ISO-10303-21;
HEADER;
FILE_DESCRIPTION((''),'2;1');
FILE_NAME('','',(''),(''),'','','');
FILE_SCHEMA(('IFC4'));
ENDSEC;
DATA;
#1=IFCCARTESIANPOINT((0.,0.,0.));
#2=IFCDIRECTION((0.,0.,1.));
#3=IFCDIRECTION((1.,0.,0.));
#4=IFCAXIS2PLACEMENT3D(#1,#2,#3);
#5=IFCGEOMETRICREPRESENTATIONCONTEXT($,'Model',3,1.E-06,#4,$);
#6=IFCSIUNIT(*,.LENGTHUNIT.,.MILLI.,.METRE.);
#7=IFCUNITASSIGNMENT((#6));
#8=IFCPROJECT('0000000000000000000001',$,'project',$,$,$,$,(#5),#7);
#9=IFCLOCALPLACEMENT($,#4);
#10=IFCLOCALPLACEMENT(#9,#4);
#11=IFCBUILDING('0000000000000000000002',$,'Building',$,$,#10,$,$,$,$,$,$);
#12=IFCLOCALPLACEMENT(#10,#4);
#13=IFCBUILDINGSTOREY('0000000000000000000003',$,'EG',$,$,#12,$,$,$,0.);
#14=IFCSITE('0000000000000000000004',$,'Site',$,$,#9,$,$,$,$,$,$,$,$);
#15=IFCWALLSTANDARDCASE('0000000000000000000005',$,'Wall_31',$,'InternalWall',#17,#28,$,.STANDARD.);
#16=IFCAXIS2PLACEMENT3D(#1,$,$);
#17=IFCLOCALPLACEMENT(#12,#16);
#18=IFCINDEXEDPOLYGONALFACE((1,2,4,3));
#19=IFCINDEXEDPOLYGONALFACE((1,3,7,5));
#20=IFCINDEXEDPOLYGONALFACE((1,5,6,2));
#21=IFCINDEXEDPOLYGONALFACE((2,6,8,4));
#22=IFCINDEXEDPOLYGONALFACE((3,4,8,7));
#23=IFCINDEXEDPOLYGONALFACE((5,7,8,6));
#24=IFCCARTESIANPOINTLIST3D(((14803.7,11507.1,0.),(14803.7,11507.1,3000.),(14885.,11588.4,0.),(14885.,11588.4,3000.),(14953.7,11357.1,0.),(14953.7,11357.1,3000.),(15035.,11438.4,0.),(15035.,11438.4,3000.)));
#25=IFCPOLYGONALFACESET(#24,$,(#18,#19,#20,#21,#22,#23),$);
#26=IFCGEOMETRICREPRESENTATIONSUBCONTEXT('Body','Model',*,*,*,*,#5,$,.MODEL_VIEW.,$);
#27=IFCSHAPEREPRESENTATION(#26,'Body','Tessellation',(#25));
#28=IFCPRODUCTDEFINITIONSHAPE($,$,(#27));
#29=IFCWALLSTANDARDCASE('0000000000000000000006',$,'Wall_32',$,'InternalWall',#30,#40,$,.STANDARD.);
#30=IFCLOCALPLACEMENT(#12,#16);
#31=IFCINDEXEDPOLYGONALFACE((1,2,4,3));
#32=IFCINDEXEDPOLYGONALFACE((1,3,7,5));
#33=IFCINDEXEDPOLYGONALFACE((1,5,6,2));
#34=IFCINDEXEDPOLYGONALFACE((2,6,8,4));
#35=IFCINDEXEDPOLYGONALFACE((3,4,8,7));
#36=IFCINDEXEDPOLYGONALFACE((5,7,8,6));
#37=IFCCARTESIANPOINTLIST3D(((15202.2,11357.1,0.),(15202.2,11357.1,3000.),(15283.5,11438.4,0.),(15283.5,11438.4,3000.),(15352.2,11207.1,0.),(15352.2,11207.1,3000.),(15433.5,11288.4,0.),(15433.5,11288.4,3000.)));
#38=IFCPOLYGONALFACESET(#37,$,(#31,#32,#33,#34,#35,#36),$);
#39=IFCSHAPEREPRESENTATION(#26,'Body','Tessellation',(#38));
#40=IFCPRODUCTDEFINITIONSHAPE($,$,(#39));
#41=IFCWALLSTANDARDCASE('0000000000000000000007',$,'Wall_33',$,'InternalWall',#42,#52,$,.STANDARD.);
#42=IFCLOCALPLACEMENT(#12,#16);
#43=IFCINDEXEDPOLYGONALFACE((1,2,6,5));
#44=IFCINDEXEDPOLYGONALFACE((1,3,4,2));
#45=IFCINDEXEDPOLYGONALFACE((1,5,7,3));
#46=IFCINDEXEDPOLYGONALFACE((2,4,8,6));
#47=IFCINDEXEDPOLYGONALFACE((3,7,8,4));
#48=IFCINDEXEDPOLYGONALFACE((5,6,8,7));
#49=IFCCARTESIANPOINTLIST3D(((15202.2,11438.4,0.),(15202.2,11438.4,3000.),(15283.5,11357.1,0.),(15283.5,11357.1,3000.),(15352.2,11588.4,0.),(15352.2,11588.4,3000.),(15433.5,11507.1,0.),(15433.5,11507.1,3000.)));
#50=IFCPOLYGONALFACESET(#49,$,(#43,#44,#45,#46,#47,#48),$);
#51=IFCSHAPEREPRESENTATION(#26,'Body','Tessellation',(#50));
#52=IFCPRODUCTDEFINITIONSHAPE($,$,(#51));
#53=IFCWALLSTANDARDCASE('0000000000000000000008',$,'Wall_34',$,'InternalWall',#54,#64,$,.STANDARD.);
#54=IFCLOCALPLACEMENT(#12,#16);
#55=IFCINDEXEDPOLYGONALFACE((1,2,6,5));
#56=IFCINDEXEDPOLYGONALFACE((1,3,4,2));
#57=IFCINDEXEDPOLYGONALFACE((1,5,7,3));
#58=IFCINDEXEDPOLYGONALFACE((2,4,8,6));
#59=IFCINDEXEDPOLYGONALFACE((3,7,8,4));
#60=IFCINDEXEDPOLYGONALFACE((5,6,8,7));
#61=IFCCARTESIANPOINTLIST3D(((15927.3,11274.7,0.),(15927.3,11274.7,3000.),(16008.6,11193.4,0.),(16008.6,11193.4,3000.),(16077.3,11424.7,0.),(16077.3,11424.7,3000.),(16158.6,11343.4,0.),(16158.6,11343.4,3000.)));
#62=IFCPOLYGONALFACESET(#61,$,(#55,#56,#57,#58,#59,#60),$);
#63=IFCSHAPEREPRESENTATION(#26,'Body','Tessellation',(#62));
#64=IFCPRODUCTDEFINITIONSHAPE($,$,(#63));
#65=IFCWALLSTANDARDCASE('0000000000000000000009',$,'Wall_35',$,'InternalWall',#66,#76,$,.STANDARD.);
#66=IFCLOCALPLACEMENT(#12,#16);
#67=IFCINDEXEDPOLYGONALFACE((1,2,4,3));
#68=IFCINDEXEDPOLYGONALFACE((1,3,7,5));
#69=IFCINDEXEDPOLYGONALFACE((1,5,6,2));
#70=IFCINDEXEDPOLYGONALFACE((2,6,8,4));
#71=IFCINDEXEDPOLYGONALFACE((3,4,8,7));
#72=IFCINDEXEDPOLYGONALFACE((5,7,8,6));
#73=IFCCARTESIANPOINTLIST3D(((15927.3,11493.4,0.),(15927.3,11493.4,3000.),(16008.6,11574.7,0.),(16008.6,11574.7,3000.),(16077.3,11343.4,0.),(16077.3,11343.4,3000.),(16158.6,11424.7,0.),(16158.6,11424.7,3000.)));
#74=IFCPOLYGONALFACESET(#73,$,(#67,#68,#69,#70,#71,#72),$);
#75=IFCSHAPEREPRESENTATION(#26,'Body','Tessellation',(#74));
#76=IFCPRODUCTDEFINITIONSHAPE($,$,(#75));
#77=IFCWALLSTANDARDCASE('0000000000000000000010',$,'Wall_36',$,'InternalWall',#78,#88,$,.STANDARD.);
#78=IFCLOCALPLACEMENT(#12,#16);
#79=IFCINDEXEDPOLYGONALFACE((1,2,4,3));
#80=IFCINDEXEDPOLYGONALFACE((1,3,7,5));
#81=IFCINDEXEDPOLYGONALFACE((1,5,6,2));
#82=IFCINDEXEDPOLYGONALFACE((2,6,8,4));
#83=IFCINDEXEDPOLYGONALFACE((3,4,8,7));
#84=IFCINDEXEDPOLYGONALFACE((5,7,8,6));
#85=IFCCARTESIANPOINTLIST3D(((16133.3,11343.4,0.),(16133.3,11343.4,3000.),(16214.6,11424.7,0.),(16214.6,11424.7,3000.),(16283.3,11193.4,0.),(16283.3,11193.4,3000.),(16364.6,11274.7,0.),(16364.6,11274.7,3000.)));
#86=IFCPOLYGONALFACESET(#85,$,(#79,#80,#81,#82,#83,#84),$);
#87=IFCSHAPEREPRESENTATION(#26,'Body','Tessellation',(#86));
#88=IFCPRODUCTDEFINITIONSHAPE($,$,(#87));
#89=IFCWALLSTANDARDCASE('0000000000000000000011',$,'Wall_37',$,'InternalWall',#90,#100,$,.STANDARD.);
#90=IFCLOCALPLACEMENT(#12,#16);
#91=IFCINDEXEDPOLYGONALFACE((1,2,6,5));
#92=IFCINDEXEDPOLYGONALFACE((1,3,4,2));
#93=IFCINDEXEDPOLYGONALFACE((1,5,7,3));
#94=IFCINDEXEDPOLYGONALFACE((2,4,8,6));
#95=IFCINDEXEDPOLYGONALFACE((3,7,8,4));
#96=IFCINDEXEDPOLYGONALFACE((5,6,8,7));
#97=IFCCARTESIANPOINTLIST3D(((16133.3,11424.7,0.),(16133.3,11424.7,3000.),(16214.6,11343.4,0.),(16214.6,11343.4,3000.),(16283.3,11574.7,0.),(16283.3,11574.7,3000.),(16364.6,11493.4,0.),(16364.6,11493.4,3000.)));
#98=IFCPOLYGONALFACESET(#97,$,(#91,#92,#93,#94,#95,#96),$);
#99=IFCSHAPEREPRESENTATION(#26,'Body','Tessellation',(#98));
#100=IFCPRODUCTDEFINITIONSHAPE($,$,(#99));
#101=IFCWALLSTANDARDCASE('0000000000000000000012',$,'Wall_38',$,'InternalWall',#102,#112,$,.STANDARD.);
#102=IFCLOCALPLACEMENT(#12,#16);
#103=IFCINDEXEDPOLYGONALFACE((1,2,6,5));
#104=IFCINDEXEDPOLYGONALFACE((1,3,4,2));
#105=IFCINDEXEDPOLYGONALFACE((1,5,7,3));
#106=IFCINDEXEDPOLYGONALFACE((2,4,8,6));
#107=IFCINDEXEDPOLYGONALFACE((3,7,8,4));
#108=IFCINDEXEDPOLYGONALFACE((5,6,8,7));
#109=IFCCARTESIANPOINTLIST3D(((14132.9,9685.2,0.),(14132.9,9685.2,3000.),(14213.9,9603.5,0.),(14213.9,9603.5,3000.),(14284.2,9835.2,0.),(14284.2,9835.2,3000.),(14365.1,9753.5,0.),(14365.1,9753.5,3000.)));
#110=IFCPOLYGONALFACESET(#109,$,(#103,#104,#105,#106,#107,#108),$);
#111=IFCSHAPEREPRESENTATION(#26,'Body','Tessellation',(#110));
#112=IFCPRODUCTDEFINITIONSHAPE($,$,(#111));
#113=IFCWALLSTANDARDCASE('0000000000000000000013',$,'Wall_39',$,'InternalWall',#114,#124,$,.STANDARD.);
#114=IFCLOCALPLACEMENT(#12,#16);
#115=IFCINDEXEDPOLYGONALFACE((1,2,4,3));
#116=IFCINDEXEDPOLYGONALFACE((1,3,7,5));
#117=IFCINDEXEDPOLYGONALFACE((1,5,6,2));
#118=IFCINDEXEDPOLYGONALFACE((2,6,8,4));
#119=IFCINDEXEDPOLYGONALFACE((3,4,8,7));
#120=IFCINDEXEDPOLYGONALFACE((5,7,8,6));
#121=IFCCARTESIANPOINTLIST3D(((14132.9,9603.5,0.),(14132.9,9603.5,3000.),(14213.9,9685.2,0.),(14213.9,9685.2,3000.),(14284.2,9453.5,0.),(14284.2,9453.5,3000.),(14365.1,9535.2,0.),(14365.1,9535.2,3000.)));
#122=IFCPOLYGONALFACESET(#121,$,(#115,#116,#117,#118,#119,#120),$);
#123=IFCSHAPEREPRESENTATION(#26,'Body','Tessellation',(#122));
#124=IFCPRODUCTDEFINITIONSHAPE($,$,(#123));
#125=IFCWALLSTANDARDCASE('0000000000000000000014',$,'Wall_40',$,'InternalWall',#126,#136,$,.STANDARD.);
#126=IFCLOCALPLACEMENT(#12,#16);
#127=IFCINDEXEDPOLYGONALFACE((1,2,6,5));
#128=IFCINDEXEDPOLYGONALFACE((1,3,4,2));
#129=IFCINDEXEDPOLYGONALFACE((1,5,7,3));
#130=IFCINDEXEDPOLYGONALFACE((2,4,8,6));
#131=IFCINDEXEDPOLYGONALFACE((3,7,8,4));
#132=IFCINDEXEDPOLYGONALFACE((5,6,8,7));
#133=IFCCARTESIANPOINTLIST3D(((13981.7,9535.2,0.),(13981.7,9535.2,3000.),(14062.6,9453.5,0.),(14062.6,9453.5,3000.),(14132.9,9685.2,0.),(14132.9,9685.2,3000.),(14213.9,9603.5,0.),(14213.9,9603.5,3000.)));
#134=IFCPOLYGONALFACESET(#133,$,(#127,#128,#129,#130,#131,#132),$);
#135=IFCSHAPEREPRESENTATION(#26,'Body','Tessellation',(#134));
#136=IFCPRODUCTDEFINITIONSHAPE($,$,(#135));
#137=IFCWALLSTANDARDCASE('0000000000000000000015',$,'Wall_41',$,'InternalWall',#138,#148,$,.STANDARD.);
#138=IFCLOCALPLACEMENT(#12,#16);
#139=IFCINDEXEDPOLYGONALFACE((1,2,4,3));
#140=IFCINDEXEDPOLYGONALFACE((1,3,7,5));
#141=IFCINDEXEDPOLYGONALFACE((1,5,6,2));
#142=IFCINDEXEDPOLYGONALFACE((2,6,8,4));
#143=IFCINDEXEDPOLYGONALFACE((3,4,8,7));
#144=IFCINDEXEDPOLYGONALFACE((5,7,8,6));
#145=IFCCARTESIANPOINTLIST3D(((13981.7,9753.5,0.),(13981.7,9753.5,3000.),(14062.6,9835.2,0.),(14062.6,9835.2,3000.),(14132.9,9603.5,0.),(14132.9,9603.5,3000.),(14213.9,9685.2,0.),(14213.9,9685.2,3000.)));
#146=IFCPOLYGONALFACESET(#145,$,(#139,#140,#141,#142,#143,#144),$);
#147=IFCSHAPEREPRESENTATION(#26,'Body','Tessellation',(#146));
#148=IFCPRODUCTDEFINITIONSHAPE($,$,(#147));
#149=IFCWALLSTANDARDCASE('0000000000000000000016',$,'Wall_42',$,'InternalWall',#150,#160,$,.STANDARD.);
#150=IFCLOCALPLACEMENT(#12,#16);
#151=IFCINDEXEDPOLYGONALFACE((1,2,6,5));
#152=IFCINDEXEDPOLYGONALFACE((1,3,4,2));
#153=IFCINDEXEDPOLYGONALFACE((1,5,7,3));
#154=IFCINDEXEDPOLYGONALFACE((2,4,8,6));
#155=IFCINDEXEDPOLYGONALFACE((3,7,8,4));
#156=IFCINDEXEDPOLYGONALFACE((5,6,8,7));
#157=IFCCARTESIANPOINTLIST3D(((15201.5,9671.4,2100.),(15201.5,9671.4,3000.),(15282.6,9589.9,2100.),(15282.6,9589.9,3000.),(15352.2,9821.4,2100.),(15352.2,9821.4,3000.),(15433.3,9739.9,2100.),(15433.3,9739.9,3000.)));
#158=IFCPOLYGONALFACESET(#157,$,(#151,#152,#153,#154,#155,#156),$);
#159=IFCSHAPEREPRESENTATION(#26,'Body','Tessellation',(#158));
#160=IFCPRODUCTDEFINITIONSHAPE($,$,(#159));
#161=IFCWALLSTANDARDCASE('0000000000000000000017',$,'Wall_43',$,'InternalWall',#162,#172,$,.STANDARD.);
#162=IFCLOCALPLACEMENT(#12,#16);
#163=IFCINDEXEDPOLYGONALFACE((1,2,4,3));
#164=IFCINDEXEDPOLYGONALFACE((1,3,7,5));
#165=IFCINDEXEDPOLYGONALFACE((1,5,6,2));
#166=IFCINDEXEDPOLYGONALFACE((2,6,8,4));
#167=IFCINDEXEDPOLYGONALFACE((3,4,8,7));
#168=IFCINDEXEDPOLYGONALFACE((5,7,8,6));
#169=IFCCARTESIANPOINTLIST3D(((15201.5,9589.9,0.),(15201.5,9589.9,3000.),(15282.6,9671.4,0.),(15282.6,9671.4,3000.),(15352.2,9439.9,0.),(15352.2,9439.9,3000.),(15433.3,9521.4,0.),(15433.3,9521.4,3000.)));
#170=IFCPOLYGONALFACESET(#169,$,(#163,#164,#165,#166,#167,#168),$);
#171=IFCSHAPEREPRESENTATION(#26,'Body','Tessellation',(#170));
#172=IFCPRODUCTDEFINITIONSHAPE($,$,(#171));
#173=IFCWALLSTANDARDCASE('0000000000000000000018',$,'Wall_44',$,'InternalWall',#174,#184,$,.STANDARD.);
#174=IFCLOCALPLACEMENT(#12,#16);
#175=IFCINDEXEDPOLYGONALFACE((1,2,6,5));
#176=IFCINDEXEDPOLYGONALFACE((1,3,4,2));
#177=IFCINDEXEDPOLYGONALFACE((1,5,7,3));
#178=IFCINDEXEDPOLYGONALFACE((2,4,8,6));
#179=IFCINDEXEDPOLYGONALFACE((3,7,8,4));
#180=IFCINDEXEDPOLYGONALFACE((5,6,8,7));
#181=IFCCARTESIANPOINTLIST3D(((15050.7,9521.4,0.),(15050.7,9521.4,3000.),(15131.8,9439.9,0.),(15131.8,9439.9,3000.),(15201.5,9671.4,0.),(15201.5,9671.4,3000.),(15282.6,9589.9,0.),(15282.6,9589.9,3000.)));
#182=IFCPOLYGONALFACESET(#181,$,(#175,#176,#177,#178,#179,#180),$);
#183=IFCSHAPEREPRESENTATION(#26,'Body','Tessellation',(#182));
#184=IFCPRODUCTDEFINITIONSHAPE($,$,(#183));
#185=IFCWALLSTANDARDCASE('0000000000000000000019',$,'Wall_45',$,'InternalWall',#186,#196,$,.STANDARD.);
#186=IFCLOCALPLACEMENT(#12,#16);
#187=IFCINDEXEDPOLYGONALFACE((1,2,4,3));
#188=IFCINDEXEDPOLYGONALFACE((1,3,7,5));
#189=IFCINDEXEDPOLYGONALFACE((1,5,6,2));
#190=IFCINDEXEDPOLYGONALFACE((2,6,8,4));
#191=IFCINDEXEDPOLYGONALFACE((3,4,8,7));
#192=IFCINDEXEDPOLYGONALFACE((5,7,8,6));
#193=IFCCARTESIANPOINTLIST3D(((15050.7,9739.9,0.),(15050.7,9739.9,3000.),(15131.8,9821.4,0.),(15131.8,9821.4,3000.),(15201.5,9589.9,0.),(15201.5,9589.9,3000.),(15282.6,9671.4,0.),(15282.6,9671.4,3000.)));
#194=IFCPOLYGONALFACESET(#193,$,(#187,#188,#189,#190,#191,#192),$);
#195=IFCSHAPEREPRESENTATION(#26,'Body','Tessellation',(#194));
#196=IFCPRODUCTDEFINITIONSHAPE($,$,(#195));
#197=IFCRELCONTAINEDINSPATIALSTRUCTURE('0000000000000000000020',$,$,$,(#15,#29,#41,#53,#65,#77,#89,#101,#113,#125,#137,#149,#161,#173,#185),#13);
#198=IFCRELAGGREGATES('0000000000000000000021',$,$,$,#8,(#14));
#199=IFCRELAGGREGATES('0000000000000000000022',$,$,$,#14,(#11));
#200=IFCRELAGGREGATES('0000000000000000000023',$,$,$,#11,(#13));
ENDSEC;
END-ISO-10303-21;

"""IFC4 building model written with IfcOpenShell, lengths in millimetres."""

from ifc_helpers import new_model, si_unit, frame, origin_with_axes, place, context, subcontext, project, spatial, rectangle, extrude, element, save


model = new_model("IFC4")

# Units and contexts
model_context = context("Model", 3, precision=1e-06, world=origin_with_axes())
body_context = subcontext(model_context, "Body", "Model", "MODEL_VIEW")
ifc_project = project(units=[si_unit("LENGTHUNIT", "METRE", prefix="MILLI")], contexts=[model_context])

# Site, building, storey
site_placement = place(None, origin_with_axes())
site = spatial("IfcSite", under=ifc_project, at=site_placement, Name="Site")
building_placement = place(site_placement, origin_with_axes())
building = spatial("IfcBuilding", under=site, at=building_placement, Name="Building")
storey_placement = place(building_placement, origin_with_axes())
storey = spatial("IfcBuildingStorey", under=building, at=storey_placement, Name="EG", Elevation=0.0)

# Walls
wall_1_placement = place(storey_placement, origin_with_axes())
element("IfcWallStandardCase", 1, at=wall_1_placement, inside=storey, Name="Wall_31", ObjectType="InternalWall", PredefinedType="STANDARD", context=body_context, shape_type="SweptSolid", body=[
    extrude(rectangle(XDim=212.1, YDim=115.0), frame((14919.4, 11472.8, 0.0), z_axis=(0.0, 0.0, 1.0), x_axis=(-0.707107, 0.707107, 0.0)), (0.0, 0.0, 1.0), 3000.0),
])
wall_2_placement = place(storey_placement, origin_with_axes())
element("IfcWallStandardCase", 2, at=wall_2_placement, inside=storey, Name="Wall_32", ObjectType="InternalWall", PredefinedType="STANDARD", context=body_context, shape_type="SweptSolid", body=[
    extrude(rectangle(XDim=212.1, YDim=115.0), frame((15317.9, 11322.8, 0.0), z_axis=(0.0, 0.0, 1.0), x_axis=(0.707107, -0.707107, 0.0)), (0.0, 0.0, 1.0), 3000.0),
])
wall_3_placement = place(storey_placement, origin_with_axes())
element("IfcWallStandardCase", 3, at=wall_3_placement, inside=storey, Name="Wall_33", ObjectType="InternalWall", PredefinedType="STANDARD", context=body_context, shape_type="SweptSolid", body=[
    extrude(rectangle(XDim=212.1, YDim=115.0), frame((15317.9, 11472.8, 0.0), z_axis=(0.0, 0.0, 1.0), x_axis=(0.707107, 0.707107, 0.0)), (0.0, 0.0, 1.0), 3000.0),
])
wall_4_placement = place(storey_placement, origin_with_axes())
element("IfcWallStandardCase", 4, at=wall_4_placement, inside=storey, Name="Wall_34", ObjectType="InternalWall", PredefinedType="STANDARD", context=body_context, shape_type="SweptSolid", body=[
    extrude(rectangle(XDim=212.1, YDim=115.0), frame((16043.0, 11309.1, 0.0), z_axis=(0.0, 0.0, 1.0), x_axis=(-0.707107, -0.707107, 0.0)), (0.0, 0.0, 1.0), 3000.0),
])
wall_5_placement = place(storey_placement, origin_with_axes())
element("IfcWallStandardCase", 5, at=wall_5_placement, inside=storey, Name="Wall_35", ObjectType="InternalWall", PredefinedType="STANDARD", context=body_context, shape_type="SweptSolid", body=[
    extrude(rectangle(XDim=212.1, YDim=115.0), frame((16043.0, 11459.1, 0.0), z_axis=(0.0, 0.0, 1.0), x_axis=(-0.707107, 0.707107, 0.0)), (0.0, 0.0, 1.0), 3000.0),
])
wall_6_placement = place(storey_placement, origin_with_axes())
element("IfcWallStandardCase", 6, at=wall_6_placement, inside=storey, Name="Wall_36", ObjectType="InternalWall", PredefinedType="STANDARD", context=body_context, shape_type="SweptSolid", body=[
    extrude(rectangle(XDim=212.1, YDim=115.0), frame((16249.0, 11309.1, 0.0), z_axis=(0.0, 0.0, 1.0), x_axis=(0.707107, -0.707107, 0.0)), (0.0, 0.0, 1.0), 3000.0),
])
wall_7_placement = place(storey_placement, origin_with_axes())
element("IfcWallStandardCase", 7, at=wall_7_placement, inside=storey, Name="Wall_37", ObjectType="InternalWall", PredefinedType="STANDARD", context=body_context, shape_type="SweptSolid", body=[
    extrude(rectangle(XDim=212.1, YDim=115.0), frame((16249.0, 11459.1, 0.0), z_axis=(0.0, 0.0, 1.0), x_axis=(0.707107, 0.707107, 0.0)), (0.0, 0.0, 1.0), 3000.0),
])
wall_8_placement = place(storey_placement, origin_with_axes())
element("IfcWallStandardCase", 8, at=wall_8_placement, inside=storey, Name="Wall_38", ObjectType="InternalWall", PredefinedType="STANDARD", context=body_context, shape_type="SweptSolid", body=[
    extrude(rectangle(XDim=213.0, YDim=115.0), frame((14249.0, 9719.3, 0.0), z_axis=(0.0, 0.0, 1.0), x_axis=(-0.710035, -0.704167, 0.0)), (0.0, 0.0, 1.0), 3000.0),
])
wall_9_placement = place(storey_placement, origin_with_axes())
element("IfcWallStandardCase", 9, at=wall_9_placement, inside=storey, Name="Wall_39", ObjectType="InternalWall", PredefinedType="STANDARD", context=body_context, shape_type="SweptSolid", body=[
    extrude(rectangle(XDim=213.0, YDim=115.0), frame((14249.0, 9569.3, 0.0), z_axis=(0.0, 0.0, 1.0), x_axis=(0.710035, -0.704167, 0.0)), (0.0, 0.0, 1.0), 3000.0),
])
wall_10_placement = place(storey_placement, origin_with_axes())
element("IfcWallStandardCase", 10, at=wall_10_placement, inside=storey, Name="Wall_40", ObjectType="InternalWall", PredefinedType="STANDARD", context=body_context, shape_type="SweptSolid", body=[
    extrude(rectangle(XDim=213.0, YDim=115.0), frame((14097.8, 9569.3, 0.0), z_axis=(0.0, 0.0, 1.0), x_axis=(-0.710035, -0.704167, 0.0)), (0.0, 0.0, 1.0), 3000.0),
])
wall_11_placement = place(storey_placement, origin_with_axes())
element("IfcWallStandardCase", 11, at=wall_11_placement, inside=storey, Name="Wall_41", ObjectType="InternalWall", PredefinedType="STANDARD", context=body_context, shape_type="SweptSolid", body=[
    extrude(rectangle(XDim=213.0, YDim=115.0), frame((14097.8, 9719.3, 0.0), z_axis=(0.0, 0.0, 1.0), x_axis=(-0.710035, 0.704167, 0.0)), (0.0, 0.0, 1.0), 3000.0),
])

# Wall, opening
wall_12_placement = place(storey_placement, origin_with_axes())
wall_12 = element("IfcWallStandardCase", 12, at=wall_12_placement, inside=storey, Name="Wall_42", ObjectType="InternalWall", PredefinedType="STANDARD", context=body_context, shape_type="SweptSolid", body=[
    extrude(rectangle(XDim=212.7, YDim=115.0), frame((15317.4, 9705.7, 0.0), z_axis=(0.0, 0.0, 1.0), x_axis=(-0.708868, -0.705341, 0.0)), (0.0, 0.0, 1.0), 3000.0),
])
opening_placement = place(wall_12_placement, origin_with_axes())
element("IfcOpeningElement", 13, at=opening_placement, inside=storey, cuts=wall_12, context=body_context, shape_type="SweptSolid", body=[
    extrude(rectangle(XDim=1662.3, YDim=115.0), frame((15405.7, 9793.5, 0.0), z_axis=(0.0, 0.0, 1.0), x_axis=(-0.708868, -0.705341, 0.0)), (0.0, 0.0, 1.0), 2100.0),
])

# Walls
wall_13_placement = place(storey_placement, origin_with_axes())
element("IfcWallStandardCase", 14, at=wall_13_placement, inside=storey, Name="Wall_43", ObjectType="InternalWall", PredefinedType="STANDARD", context=body_context, shape_type="SweptSolid", body=[
    extrude(rectangle(XDim=212.7, YDim=115.0), frame((15317.4, 9555.7, 0.0), z_axis=(0.0, 0.0, 1.0), x_axis=(0.708868, -0.705341, 0.0)), (0.0, 0.0, 1.0), 3000.0),
])
wall_14_placement = place(storey_placement, origin_with_axes())
element("IfcWallStandardCase", 15, at=wall_14_placement, inside=storey, Name="Wall_44", ObjectType="InternalWall", PredefinedType="STANDARD", context=body_context, shape_type="SweptSolid", body=[
    extrude(rectangle(XDim=212.7, YDim=115.0), frame((15166.6, 9555.7, 0.0), z_axis=(0.0, 0.0, 1.0), x_axis=(-0.708868, -0.705341, 0.0)), (0.0, 0.0, 1.0), 3000.0),
])
wall_15_placement = place(storey_placement, origin_with_axes())
element("IfcWallStandardCase", 16, at=wall_15_placement, inside=storey, Name="Wall_45", ObjectType="InternalWall", PredefinedType="STANDARD", context=body_context, shape_type="SweptSolid", body=[
    extrude(rectangle(XDim=212.7, YDim=115.0), frame((15166.6, 9705.7, 0.0), z_axis=(0.0, 0.0, 1.0), x_axis=(-0.708868, 0.705341, 0.0)), (0.0, 0.0, 1.0), 3000.0),
])

save(model, "model.ifc")
